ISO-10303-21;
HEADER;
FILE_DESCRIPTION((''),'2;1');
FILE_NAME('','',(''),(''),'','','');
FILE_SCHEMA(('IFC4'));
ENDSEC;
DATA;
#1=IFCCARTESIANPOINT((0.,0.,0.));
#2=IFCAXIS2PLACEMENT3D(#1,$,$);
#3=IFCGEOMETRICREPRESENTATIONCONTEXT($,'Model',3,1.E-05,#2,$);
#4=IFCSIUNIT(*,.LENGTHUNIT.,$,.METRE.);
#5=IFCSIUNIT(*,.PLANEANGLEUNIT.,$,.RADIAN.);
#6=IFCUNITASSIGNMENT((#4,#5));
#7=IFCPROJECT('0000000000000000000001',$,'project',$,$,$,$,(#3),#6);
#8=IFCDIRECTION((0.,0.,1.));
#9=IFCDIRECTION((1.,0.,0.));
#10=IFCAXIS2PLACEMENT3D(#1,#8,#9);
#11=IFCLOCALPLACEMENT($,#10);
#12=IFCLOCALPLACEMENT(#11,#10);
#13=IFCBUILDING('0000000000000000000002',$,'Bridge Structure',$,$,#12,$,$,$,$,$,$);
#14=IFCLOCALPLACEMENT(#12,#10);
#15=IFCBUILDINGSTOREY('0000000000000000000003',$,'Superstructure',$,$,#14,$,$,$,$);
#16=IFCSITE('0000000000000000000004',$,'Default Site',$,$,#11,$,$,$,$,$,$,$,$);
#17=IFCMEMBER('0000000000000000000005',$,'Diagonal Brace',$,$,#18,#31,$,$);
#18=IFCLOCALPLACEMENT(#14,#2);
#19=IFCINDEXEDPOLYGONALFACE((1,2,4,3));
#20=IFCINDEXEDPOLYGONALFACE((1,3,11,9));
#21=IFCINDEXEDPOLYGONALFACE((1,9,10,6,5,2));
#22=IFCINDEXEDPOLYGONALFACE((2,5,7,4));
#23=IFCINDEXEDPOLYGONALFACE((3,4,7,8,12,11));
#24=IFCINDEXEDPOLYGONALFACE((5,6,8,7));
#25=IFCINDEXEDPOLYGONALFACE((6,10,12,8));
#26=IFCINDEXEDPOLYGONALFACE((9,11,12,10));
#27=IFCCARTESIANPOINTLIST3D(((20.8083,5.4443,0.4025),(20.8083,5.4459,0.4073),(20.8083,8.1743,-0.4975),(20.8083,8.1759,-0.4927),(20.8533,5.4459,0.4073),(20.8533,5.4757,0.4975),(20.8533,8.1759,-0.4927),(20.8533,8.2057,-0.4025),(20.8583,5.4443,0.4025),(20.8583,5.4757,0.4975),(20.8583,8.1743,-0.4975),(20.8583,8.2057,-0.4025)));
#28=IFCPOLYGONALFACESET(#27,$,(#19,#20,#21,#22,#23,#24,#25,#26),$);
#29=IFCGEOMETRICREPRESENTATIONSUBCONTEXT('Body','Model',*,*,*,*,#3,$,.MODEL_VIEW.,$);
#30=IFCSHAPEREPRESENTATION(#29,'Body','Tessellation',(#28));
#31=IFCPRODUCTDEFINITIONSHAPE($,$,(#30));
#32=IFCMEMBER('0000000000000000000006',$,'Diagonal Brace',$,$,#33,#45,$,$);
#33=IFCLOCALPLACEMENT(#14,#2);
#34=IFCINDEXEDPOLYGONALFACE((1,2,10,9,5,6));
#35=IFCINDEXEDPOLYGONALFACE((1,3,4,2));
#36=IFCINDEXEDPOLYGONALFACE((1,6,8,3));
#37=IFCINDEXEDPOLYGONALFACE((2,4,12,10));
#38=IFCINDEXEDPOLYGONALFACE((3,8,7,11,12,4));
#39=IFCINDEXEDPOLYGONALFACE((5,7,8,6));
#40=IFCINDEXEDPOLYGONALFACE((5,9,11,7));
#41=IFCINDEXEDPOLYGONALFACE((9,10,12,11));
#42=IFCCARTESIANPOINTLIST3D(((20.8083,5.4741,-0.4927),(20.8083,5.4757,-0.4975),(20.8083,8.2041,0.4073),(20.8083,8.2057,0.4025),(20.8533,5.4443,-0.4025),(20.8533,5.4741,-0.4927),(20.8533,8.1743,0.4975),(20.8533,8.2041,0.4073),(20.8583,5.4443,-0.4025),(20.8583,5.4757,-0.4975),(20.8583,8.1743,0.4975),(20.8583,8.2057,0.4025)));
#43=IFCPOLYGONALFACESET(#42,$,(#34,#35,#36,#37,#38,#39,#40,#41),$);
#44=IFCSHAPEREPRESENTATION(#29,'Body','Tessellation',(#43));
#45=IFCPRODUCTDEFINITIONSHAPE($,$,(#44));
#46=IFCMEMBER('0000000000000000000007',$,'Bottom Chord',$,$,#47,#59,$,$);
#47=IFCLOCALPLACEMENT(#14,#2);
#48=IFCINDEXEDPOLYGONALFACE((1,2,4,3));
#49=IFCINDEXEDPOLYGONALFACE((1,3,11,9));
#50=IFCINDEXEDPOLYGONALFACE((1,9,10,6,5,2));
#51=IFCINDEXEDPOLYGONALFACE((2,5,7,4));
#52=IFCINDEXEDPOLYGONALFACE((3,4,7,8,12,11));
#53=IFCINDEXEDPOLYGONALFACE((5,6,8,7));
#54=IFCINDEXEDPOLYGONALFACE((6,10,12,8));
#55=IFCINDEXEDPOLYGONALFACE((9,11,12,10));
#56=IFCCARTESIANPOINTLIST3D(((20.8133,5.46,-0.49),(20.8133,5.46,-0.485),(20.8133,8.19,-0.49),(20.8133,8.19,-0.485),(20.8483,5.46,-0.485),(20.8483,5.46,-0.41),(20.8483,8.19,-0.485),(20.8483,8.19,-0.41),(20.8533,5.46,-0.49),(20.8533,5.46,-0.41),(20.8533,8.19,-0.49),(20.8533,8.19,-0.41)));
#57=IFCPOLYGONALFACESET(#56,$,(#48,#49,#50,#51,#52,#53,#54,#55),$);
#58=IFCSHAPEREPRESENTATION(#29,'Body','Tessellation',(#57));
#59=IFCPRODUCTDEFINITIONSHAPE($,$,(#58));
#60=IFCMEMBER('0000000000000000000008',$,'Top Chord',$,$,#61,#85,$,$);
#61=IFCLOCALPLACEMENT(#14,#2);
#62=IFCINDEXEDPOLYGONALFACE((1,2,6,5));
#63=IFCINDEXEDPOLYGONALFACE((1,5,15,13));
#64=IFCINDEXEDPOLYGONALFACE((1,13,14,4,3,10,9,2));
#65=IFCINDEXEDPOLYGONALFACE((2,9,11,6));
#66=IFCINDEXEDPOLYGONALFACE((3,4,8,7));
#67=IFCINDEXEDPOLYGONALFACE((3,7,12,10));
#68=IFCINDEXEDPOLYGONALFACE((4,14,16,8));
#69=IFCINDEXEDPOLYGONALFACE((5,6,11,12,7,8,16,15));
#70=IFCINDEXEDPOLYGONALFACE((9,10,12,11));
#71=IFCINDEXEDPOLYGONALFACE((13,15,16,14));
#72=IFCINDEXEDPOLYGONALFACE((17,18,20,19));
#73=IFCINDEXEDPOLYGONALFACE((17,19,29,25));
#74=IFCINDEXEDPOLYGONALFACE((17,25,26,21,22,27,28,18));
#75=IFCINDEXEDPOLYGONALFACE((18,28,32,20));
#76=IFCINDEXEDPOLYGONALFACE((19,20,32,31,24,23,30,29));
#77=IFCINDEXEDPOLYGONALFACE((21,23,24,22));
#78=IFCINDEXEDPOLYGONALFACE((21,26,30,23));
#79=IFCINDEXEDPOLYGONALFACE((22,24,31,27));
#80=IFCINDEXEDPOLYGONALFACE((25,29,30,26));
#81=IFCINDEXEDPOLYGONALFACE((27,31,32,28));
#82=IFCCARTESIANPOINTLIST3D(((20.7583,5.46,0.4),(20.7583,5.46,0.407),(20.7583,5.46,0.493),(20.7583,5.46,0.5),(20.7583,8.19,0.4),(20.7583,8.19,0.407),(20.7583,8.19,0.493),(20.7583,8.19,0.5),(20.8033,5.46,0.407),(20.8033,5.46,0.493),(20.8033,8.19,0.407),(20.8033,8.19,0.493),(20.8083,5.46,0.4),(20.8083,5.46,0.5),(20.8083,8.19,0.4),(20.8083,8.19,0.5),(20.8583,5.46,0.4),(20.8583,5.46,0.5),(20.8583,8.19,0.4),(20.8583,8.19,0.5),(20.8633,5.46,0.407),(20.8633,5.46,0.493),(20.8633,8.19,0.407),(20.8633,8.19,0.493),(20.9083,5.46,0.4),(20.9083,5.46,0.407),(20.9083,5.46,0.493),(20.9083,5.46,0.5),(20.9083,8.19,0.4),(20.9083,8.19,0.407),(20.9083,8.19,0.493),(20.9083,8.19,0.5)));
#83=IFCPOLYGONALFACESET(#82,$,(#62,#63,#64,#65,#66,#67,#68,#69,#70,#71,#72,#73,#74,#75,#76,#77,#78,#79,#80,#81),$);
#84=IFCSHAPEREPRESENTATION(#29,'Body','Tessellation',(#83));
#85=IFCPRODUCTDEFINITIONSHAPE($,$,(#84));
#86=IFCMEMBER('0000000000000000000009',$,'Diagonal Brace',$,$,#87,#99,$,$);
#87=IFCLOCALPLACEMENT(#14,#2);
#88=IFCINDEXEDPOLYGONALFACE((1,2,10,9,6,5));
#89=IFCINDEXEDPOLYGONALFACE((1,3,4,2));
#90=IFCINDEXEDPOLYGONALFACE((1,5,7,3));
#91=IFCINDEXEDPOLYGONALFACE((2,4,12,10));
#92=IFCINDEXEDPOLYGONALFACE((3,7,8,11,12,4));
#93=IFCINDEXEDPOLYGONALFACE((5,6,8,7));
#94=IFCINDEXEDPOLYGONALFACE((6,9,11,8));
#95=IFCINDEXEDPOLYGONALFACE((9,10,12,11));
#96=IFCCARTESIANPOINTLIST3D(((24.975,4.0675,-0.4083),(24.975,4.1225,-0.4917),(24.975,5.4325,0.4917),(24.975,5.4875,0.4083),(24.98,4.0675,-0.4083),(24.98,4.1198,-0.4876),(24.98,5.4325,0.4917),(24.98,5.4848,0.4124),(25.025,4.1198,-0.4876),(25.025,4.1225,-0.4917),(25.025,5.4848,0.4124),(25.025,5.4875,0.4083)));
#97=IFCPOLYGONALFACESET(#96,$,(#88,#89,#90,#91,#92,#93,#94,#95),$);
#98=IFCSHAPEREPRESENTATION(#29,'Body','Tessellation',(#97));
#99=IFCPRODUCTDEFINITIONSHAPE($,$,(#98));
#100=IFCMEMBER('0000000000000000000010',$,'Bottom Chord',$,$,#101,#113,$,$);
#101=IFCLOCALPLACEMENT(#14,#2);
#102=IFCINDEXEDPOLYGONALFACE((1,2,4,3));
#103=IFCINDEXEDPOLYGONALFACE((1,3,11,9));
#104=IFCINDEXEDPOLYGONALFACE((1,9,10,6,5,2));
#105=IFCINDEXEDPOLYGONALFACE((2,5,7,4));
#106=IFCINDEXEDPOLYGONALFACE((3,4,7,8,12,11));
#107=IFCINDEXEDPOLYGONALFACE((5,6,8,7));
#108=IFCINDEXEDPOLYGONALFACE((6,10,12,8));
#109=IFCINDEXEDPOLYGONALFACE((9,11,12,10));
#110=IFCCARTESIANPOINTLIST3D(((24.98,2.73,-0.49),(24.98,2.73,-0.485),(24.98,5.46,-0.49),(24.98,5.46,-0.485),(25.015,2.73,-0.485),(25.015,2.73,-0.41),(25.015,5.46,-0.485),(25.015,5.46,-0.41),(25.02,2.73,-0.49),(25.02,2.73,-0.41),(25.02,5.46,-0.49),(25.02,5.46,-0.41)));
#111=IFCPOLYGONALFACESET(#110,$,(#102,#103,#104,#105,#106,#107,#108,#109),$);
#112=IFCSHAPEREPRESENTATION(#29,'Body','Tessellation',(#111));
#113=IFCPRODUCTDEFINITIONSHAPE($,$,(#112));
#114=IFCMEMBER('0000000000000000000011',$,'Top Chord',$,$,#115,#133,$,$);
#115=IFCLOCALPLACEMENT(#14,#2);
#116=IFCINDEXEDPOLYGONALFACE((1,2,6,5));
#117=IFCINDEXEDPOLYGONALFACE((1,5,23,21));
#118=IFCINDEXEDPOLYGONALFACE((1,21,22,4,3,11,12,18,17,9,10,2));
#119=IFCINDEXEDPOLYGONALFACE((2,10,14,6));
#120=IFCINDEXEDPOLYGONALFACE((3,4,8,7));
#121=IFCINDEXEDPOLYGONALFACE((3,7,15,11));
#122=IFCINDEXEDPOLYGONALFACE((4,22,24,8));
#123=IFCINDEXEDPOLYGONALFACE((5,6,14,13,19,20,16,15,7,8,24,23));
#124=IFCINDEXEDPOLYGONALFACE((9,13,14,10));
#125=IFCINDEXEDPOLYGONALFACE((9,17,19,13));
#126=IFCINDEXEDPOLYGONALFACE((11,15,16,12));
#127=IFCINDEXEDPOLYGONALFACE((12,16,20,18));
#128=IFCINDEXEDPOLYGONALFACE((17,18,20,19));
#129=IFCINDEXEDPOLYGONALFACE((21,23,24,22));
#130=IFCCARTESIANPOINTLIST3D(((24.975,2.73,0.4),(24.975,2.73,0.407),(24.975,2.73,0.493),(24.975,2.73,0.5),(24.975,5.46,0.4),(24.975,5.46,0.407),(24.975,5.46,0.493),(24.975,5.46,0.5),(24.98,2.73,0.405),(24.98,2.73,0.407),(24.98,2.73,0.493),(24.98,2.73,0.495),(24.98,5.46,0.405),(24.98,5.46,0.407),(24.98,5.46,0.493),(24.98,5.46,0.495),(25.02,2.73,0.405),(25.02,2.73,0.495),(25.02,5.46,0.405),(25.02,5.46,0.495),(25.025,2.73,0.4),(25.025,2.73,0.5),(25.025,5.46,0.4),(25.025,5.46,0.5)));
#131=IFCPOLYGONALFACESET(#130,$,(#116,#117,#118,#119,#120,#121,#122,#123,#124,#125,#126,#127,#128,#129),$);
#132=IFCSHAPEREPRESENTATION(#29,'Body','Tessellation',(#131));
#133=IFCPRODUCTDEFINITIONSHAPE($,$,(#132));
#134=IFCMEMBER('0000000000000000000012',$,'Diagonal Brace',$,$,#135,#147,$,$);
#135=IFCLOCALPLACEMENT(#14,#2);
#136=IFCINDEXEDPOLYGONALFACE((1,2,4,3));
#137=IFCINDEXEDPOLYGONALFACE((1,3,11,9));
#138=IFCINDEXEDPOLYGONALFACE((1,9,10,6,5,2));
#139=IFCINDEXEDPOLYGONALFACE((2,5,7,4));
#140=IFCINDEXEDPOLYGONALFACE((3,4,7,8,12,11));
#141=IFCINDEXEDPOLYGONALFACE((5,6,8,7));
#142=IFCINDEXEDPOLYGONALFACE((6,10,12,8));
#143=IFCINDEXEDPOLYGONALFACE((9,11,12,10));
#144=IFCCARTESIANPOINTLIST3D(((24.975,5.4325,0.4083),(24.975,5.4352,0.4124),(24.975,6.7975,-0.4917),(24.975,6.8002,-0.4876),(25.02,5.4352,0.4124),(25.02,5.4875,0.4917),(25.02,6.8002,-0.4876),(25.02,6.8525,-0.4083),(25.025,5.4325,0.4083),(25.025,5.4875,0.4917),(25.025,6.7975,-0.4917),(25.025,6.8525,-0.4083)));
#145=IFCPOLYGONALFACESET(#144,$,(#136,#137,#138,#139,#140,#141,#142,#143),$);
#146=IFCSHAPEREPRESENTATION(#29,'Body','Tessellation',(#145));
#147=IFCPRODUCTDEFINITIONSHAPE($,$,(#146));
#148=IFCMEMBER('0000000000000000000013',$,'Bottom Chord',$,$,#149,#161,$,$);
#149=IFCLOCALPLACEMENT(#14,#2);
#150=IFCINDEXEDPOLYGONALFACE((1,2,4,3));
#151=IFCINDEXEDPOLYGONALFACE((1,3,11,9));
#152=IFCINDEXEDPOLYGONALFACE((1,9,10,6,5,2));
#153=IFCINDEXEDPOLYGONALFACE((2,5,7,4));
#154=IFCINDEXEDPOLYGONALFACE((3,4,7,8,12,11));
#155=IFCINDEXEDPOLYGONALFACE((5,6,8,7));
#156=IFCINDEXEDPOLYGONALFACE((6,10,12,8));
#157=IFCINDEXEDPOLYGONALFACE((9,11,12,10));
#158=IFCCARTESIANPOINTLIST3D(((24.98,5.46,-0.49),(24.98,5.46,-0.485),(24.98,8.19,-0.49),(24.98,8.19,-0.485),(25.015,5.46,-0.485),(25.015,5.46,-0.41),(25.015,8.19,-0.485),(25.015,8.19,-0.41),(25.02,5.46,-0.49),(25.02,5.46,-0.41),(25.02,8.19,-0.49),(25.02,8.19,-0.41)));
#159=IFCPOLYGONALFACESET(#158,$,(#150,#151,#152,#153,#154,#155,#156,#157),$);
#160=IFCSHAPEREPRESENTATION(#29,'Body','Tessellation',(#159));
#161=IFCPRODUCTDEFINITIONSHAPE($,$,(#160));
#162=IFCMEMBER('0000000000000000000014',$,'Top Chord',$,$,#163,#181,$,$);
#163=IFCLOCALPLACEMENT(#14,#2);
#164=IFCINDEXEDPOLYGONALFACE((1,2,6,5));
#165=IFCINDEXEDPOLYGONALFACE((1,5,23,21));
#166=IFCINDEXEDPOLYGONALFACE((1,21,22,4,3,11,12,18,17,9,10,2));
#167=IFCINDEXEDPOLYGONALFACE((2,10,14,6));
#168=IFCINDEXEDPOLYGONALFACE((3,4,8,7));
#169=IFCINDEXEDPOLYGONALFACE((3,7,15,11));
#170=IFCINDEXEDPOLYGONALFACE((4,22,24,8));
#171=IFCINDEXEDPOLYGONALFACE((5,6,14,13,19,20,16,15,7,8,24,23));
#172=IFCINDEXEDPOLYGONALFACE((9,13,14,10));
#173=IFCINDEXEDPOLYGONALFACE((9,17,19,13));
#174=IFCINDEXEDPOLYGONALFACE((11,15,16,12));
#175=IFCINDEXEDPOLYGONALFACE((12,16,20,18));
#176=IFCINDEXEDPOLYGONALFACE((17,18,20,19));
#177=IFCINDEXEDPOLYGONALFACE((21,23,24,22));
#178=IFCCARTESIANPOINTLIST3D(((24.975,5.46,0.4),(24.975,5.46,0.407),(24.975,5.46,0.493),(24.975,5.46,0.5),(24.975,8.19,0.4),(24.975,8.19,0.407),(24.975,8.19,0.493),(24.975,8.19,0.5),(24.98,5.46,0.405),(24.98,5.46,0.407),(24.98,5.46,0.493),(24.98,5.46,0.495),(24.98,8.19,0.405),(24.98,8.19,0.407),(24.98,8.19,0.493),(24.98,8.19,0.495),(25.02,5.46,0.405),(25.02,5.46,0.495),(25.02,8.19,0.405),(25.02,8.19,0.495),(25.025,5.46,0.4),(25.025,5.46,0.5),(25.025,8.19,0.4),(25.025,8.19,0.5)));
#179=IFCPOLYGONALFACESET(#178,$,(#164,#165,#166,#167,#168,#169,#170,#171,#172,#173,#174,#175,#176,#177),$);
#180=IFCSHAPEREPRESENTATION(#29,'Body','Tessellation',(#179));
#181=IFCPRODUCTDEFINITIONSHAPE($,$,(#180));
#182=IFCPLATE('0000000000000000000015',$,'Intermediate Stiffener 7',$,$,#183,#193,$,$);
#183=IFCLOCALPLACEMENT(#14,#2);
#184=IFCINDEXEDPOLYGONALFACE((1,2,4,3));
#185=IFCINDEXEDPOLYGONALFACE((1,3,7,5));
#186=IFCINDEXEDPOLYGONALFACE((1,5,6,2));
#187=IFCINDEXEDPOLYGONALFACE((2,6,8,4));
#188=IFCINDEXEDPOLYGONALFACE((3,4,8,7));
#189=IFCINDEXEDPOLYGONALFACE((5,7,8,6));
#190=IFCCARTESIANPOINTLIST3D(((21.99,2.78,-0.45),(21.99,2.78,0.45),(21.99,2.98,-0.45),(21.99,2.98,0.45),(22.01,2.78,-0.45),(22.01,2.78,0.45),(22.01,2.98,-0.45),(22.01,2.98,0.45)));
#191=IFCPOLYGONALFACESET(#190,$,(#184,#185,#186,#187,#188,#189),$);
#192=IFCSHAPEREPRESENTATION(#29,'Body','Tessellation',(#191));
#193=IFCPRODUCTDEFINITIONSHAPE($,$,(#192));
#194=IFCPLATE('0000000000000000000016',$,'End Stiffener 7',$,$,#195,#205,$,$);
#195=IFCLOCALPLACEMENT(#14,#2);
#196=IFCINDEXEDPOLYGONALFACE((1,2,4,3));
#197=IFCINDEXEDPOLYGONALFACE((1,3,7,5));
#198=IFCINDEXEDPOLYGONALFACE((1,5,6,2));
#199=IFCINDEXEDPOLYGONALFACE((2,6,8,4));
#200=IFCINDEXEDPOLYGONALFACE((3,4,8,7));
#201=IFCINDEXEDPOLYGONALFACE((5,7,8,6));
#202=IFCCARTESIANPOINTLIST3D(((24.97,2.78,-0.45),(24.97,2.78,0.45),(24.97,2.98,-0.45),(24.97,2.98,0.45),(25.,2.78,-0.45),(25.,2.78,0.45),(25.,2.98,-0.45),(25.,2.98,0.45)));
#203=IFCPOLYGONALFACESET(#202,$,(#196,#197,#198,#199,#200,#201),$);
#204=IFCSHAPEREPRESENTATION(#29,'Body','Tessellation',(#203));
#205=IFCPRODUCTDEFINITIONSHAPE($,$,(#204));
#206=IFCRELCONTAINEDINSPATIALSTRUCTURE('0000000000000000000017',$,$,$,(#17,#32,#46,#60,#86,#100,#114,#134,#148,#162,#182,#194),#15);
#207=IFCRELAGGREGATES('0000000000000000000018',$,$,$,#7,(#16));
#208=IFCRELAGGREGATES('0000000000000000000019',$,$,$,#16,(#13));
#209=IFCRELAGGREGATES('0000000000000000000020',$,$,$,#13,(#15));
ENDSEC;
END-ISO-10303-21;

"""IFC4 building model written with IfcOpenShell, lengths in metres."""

from ifc_helpers import new_model, si_unit, frame, origin, origin_with_axes, origin_2d_with_axis, place, context, subcontext, project, spatial, polyline, rectangle, l_section, c_section, outline, composite_profile, extrude, element, save


model = new_model("IFC4")

# Units and contexts
model_context = context("Model", 3, precision=1e-05, world=origin())
body_context = subcontext(model_context, "Body", "Model", "MODEL_VIEW")
ifc_project = project(units=[si_unit("LENGTHUNIT", "METRE"), si_unit("PLANEANGLEUNIT", "RADIAN")], contexts=[model_context])

# Site, building, storey
site_placement = place(None, origin_with_axes())
site = spatial("IfcSite", under=ifc_project, at=site_placement, Name="Default Site")
building_placement = place(site_placement, origin_with_axes())
building = spatial("IfcBuilding", under=site, at=building_placement, Name="Bridge Structure")
storey_placement = place(building_placement, origin_with_axes())
storey = spatial("IfcBuildingStorey", under=building, at=storey_placement, Name="Superstructure")

# Members
for number, where, z_axis, x_axis, name in (
    (1, (20.8333, 5.46, 0.45), (0.0, 0.949722, -0.313095), (-1.0, 0.0, 0.0), "Diagonal Brace"),
    (2, (20.8333, 5.46, -0.45), (0.0, 0.949722, 0.313095), (-1.0, 0.0, 0.0), "Diagonal Brace"),
):
    element("IfcMember", number, at=place(storey_placement, frame(where, z_axis=z_axis, x_axis=x_axis)), inside=storey, Name=name, context=body_context, shape_type="SweptSolid", body=[
        extrude(l_section(Depth=0.1, Width=0.05, Thickness=0.005, at=origin_2d_with_axis()), origin_with_axes(), (0.0, 0.0, 1.0), 2.8745),
    ])
member_1_placement = place(storey_placement, frame((20.8333, 5.46, -0.45), z_axis=(0.0, 1.0, 0.0), x_axis=(-1.0, 0.0, 0.0)))
element("IfcMember", 3, at=member_1_placement, inside=storey, Name="Bottom Chord", context=body_context, shape_type="SweptSolid", body=[
    extrude(l_section(Depth=0.08, Width=0.04, Thickness=0.005, at=origin_2d_with_axis()), origin_with_axes(), (0.0, 0.0, 1.0), 2.73),
])
member_2_placement = place(storey_placement, frame((20.8333, 5.46, 0.45), z_axis=(0.0, 1.0, 0.0), x_axis=(-1.0, 0.0, 0.0)))
element("IfcMember", 4, at=member_2_placement, inside=storey, Name="Top Chord", context=body_context, shape_type="SweptSolid", body=[
    extrude(composite_profile([outline(polyline([(-0.025, -0.05), (-0.025, 0.05), (-0.075, 0.05), (-0.075, 0.043), (-0.03, 0.043), (-0.03, -0.043), (-0.075, -0.043), (-0.075, -0.05), (-0.025, -0.05)])), outline(polyline([(0.025, -0.05), (0.075, -0.05), (0.075, -0.043), (0.03, -0.043), (0.03, 0.043), (0.075, 0.043), (0.075, 0.05), (0.025, 0.05), (0.025, -0.05)]))]), origin_with_axes(), (0.0, 0.0, 1.0), 2.73),
])
member_3_placement = place(storey_placement, frame((25.0, 5.46, 0.45), z_axis=(0.0, -0.834862, -0.550459), x_axis=(1.0, 0.0, 0.0)))
element("IfcMember", 5, at=member_3_placement, inside=storey, Name="Diagonal Brace", context=body_context, shape_type="SweptSolid", body=[
    extrude(l_section(Depth=0.1, Width=0.05, Thickness=0.005, at=origin_2d_with_axis()), origin_with_axes(), (0.0, 0.0, 1.0), 1.635),
])
member_4_placement = place(storey_placement, frame((25.0, 2.73, -0.45), z_axis=(0.0, 1.0, 0.0), x_axis=(-1.0, 0.0, 0.0)))
element("IfcMember", 6, at=member_4_placement, inside=storey, Name="Bottom Chord", context=body_context, shape_type="SweptSolid", body=[
    extrude(l_section(Depth=0.08, Width=0.04, Thickness=0.005, at=origin_2d_with_axis()), origin_with_axes(), (0.0, 0.0, 1.0), 2.73),
])
member_5_placement = place(storey_placement, frame((25.0, 2.73, 0.45), z_axis=(0.0, 1.0, 0.0), x_axis=(-1.0, 0.0, 0.0)))
element("IfcMember", 7, at=member_5_placement, inside=storey, Name="Top Chord", context=body_context, shape_type="SweptSolid", body=[
    extrude(c_section(Depth=0.1, Width=0.05, WallThickness=0.005, Girth=0.007, at=origin_2d_with_axis()), origin_with_axes(), (0.0, 0.0, 1.0), 2.73),
])
member_6_placement = place(storey_placement, frame((25.0, 5.46, 0.45), z_axis=(0.0, 0.834862, -0.550459), x_axis=(-1.0, 0.0, 0.0)))
element("IfcMember", 8, at=member_6_placement, inside=storey, Name="Diagonal Brace", context=body_context, shape_type="SweptSolid", body=[
    extrude(l_section(Depth=0.1, Width=0.05, Thickness=0.005, at=origin_2d_with_axis()), origin_with_axes(), (0.0, 0.0, 1.0), 1.635),
])
member_7_placement = place(storey_placement, frame((25.0, 5.46, -0.45), z_axis=(0.0, 1.0, 0.0), x_axis=(-1.0, 0.0, 0.0)))
element("IfcMember", 9, at=member_7_placement, inside=storey, Name="Bottom Chord", context=body_context, shape_type="SweptSolid", body=[
    extrude(l_section(Depth=0.08, Width=0.04, Thickness=0.005, at=origin_2d_with_axis()), origin_with_axes(), (0.0, 0.0, 1.0), 2.73),
])
member_8_placement = place(storey_placement, frame((25.0, 5.46, 0.45), z_axis=(0.0, 1.0, 0.0), x_axis=(-1.0, 0.0, 0.0)))
element("IfcMember", 10, at=member_8_placement, inside=storey, Name="Top Chord", context=body_context, shape_type="SweptSolid", body=[
    extrude(c_section(Depth=0.1, Width=0.05, WallThickness=0.005, Girth=0.007, at=origin_2d_with_axis()), origin_with_axes(), (0.0, 0.0, 1.0), 2.73),
])

# Plates
plate_placement = place(storey_placement, frame((22.0, 2.88, -0.45), z_axis=(0.0, 0.0, 1.0), x_axis=(1.0, 0.0, 0.0)))
element("IfcPlate", 11, at=plate_placement, inside=storey, Name="Intermediate Stiffener 7", context=body_context, shape_type="SweptSolid", body=[
    extrude(rectangle(XDim=0.02, YDim=0.2, at=origin_2d_with_axis()), origin_with_axes(), (0.0, 0.0, 1.0), 0.9),
])
for number, where, z_axis, x_axis, name in (
    (12, (24.985, 2.88, -0.45), (0.0, 0.0, 1.0), (1.0, 0.0, 0.0), "End Stiffener 7"),
):
    element("IfcPlate", number, at=place(storey_placement, frame(where, z_axis=z_axis, x_axis=x_axis)), inside=storey, Name=name, context=body_context, shape_type="SweptSolid", body=[
        extrude(rectangle(XDim=0.03, YDim=0.2, at=origin_2d_with_axis()), origin_with_axes(), (0.0, 0.0, 1.0), 0.9),
    ])

save(model, "model.ifc")
